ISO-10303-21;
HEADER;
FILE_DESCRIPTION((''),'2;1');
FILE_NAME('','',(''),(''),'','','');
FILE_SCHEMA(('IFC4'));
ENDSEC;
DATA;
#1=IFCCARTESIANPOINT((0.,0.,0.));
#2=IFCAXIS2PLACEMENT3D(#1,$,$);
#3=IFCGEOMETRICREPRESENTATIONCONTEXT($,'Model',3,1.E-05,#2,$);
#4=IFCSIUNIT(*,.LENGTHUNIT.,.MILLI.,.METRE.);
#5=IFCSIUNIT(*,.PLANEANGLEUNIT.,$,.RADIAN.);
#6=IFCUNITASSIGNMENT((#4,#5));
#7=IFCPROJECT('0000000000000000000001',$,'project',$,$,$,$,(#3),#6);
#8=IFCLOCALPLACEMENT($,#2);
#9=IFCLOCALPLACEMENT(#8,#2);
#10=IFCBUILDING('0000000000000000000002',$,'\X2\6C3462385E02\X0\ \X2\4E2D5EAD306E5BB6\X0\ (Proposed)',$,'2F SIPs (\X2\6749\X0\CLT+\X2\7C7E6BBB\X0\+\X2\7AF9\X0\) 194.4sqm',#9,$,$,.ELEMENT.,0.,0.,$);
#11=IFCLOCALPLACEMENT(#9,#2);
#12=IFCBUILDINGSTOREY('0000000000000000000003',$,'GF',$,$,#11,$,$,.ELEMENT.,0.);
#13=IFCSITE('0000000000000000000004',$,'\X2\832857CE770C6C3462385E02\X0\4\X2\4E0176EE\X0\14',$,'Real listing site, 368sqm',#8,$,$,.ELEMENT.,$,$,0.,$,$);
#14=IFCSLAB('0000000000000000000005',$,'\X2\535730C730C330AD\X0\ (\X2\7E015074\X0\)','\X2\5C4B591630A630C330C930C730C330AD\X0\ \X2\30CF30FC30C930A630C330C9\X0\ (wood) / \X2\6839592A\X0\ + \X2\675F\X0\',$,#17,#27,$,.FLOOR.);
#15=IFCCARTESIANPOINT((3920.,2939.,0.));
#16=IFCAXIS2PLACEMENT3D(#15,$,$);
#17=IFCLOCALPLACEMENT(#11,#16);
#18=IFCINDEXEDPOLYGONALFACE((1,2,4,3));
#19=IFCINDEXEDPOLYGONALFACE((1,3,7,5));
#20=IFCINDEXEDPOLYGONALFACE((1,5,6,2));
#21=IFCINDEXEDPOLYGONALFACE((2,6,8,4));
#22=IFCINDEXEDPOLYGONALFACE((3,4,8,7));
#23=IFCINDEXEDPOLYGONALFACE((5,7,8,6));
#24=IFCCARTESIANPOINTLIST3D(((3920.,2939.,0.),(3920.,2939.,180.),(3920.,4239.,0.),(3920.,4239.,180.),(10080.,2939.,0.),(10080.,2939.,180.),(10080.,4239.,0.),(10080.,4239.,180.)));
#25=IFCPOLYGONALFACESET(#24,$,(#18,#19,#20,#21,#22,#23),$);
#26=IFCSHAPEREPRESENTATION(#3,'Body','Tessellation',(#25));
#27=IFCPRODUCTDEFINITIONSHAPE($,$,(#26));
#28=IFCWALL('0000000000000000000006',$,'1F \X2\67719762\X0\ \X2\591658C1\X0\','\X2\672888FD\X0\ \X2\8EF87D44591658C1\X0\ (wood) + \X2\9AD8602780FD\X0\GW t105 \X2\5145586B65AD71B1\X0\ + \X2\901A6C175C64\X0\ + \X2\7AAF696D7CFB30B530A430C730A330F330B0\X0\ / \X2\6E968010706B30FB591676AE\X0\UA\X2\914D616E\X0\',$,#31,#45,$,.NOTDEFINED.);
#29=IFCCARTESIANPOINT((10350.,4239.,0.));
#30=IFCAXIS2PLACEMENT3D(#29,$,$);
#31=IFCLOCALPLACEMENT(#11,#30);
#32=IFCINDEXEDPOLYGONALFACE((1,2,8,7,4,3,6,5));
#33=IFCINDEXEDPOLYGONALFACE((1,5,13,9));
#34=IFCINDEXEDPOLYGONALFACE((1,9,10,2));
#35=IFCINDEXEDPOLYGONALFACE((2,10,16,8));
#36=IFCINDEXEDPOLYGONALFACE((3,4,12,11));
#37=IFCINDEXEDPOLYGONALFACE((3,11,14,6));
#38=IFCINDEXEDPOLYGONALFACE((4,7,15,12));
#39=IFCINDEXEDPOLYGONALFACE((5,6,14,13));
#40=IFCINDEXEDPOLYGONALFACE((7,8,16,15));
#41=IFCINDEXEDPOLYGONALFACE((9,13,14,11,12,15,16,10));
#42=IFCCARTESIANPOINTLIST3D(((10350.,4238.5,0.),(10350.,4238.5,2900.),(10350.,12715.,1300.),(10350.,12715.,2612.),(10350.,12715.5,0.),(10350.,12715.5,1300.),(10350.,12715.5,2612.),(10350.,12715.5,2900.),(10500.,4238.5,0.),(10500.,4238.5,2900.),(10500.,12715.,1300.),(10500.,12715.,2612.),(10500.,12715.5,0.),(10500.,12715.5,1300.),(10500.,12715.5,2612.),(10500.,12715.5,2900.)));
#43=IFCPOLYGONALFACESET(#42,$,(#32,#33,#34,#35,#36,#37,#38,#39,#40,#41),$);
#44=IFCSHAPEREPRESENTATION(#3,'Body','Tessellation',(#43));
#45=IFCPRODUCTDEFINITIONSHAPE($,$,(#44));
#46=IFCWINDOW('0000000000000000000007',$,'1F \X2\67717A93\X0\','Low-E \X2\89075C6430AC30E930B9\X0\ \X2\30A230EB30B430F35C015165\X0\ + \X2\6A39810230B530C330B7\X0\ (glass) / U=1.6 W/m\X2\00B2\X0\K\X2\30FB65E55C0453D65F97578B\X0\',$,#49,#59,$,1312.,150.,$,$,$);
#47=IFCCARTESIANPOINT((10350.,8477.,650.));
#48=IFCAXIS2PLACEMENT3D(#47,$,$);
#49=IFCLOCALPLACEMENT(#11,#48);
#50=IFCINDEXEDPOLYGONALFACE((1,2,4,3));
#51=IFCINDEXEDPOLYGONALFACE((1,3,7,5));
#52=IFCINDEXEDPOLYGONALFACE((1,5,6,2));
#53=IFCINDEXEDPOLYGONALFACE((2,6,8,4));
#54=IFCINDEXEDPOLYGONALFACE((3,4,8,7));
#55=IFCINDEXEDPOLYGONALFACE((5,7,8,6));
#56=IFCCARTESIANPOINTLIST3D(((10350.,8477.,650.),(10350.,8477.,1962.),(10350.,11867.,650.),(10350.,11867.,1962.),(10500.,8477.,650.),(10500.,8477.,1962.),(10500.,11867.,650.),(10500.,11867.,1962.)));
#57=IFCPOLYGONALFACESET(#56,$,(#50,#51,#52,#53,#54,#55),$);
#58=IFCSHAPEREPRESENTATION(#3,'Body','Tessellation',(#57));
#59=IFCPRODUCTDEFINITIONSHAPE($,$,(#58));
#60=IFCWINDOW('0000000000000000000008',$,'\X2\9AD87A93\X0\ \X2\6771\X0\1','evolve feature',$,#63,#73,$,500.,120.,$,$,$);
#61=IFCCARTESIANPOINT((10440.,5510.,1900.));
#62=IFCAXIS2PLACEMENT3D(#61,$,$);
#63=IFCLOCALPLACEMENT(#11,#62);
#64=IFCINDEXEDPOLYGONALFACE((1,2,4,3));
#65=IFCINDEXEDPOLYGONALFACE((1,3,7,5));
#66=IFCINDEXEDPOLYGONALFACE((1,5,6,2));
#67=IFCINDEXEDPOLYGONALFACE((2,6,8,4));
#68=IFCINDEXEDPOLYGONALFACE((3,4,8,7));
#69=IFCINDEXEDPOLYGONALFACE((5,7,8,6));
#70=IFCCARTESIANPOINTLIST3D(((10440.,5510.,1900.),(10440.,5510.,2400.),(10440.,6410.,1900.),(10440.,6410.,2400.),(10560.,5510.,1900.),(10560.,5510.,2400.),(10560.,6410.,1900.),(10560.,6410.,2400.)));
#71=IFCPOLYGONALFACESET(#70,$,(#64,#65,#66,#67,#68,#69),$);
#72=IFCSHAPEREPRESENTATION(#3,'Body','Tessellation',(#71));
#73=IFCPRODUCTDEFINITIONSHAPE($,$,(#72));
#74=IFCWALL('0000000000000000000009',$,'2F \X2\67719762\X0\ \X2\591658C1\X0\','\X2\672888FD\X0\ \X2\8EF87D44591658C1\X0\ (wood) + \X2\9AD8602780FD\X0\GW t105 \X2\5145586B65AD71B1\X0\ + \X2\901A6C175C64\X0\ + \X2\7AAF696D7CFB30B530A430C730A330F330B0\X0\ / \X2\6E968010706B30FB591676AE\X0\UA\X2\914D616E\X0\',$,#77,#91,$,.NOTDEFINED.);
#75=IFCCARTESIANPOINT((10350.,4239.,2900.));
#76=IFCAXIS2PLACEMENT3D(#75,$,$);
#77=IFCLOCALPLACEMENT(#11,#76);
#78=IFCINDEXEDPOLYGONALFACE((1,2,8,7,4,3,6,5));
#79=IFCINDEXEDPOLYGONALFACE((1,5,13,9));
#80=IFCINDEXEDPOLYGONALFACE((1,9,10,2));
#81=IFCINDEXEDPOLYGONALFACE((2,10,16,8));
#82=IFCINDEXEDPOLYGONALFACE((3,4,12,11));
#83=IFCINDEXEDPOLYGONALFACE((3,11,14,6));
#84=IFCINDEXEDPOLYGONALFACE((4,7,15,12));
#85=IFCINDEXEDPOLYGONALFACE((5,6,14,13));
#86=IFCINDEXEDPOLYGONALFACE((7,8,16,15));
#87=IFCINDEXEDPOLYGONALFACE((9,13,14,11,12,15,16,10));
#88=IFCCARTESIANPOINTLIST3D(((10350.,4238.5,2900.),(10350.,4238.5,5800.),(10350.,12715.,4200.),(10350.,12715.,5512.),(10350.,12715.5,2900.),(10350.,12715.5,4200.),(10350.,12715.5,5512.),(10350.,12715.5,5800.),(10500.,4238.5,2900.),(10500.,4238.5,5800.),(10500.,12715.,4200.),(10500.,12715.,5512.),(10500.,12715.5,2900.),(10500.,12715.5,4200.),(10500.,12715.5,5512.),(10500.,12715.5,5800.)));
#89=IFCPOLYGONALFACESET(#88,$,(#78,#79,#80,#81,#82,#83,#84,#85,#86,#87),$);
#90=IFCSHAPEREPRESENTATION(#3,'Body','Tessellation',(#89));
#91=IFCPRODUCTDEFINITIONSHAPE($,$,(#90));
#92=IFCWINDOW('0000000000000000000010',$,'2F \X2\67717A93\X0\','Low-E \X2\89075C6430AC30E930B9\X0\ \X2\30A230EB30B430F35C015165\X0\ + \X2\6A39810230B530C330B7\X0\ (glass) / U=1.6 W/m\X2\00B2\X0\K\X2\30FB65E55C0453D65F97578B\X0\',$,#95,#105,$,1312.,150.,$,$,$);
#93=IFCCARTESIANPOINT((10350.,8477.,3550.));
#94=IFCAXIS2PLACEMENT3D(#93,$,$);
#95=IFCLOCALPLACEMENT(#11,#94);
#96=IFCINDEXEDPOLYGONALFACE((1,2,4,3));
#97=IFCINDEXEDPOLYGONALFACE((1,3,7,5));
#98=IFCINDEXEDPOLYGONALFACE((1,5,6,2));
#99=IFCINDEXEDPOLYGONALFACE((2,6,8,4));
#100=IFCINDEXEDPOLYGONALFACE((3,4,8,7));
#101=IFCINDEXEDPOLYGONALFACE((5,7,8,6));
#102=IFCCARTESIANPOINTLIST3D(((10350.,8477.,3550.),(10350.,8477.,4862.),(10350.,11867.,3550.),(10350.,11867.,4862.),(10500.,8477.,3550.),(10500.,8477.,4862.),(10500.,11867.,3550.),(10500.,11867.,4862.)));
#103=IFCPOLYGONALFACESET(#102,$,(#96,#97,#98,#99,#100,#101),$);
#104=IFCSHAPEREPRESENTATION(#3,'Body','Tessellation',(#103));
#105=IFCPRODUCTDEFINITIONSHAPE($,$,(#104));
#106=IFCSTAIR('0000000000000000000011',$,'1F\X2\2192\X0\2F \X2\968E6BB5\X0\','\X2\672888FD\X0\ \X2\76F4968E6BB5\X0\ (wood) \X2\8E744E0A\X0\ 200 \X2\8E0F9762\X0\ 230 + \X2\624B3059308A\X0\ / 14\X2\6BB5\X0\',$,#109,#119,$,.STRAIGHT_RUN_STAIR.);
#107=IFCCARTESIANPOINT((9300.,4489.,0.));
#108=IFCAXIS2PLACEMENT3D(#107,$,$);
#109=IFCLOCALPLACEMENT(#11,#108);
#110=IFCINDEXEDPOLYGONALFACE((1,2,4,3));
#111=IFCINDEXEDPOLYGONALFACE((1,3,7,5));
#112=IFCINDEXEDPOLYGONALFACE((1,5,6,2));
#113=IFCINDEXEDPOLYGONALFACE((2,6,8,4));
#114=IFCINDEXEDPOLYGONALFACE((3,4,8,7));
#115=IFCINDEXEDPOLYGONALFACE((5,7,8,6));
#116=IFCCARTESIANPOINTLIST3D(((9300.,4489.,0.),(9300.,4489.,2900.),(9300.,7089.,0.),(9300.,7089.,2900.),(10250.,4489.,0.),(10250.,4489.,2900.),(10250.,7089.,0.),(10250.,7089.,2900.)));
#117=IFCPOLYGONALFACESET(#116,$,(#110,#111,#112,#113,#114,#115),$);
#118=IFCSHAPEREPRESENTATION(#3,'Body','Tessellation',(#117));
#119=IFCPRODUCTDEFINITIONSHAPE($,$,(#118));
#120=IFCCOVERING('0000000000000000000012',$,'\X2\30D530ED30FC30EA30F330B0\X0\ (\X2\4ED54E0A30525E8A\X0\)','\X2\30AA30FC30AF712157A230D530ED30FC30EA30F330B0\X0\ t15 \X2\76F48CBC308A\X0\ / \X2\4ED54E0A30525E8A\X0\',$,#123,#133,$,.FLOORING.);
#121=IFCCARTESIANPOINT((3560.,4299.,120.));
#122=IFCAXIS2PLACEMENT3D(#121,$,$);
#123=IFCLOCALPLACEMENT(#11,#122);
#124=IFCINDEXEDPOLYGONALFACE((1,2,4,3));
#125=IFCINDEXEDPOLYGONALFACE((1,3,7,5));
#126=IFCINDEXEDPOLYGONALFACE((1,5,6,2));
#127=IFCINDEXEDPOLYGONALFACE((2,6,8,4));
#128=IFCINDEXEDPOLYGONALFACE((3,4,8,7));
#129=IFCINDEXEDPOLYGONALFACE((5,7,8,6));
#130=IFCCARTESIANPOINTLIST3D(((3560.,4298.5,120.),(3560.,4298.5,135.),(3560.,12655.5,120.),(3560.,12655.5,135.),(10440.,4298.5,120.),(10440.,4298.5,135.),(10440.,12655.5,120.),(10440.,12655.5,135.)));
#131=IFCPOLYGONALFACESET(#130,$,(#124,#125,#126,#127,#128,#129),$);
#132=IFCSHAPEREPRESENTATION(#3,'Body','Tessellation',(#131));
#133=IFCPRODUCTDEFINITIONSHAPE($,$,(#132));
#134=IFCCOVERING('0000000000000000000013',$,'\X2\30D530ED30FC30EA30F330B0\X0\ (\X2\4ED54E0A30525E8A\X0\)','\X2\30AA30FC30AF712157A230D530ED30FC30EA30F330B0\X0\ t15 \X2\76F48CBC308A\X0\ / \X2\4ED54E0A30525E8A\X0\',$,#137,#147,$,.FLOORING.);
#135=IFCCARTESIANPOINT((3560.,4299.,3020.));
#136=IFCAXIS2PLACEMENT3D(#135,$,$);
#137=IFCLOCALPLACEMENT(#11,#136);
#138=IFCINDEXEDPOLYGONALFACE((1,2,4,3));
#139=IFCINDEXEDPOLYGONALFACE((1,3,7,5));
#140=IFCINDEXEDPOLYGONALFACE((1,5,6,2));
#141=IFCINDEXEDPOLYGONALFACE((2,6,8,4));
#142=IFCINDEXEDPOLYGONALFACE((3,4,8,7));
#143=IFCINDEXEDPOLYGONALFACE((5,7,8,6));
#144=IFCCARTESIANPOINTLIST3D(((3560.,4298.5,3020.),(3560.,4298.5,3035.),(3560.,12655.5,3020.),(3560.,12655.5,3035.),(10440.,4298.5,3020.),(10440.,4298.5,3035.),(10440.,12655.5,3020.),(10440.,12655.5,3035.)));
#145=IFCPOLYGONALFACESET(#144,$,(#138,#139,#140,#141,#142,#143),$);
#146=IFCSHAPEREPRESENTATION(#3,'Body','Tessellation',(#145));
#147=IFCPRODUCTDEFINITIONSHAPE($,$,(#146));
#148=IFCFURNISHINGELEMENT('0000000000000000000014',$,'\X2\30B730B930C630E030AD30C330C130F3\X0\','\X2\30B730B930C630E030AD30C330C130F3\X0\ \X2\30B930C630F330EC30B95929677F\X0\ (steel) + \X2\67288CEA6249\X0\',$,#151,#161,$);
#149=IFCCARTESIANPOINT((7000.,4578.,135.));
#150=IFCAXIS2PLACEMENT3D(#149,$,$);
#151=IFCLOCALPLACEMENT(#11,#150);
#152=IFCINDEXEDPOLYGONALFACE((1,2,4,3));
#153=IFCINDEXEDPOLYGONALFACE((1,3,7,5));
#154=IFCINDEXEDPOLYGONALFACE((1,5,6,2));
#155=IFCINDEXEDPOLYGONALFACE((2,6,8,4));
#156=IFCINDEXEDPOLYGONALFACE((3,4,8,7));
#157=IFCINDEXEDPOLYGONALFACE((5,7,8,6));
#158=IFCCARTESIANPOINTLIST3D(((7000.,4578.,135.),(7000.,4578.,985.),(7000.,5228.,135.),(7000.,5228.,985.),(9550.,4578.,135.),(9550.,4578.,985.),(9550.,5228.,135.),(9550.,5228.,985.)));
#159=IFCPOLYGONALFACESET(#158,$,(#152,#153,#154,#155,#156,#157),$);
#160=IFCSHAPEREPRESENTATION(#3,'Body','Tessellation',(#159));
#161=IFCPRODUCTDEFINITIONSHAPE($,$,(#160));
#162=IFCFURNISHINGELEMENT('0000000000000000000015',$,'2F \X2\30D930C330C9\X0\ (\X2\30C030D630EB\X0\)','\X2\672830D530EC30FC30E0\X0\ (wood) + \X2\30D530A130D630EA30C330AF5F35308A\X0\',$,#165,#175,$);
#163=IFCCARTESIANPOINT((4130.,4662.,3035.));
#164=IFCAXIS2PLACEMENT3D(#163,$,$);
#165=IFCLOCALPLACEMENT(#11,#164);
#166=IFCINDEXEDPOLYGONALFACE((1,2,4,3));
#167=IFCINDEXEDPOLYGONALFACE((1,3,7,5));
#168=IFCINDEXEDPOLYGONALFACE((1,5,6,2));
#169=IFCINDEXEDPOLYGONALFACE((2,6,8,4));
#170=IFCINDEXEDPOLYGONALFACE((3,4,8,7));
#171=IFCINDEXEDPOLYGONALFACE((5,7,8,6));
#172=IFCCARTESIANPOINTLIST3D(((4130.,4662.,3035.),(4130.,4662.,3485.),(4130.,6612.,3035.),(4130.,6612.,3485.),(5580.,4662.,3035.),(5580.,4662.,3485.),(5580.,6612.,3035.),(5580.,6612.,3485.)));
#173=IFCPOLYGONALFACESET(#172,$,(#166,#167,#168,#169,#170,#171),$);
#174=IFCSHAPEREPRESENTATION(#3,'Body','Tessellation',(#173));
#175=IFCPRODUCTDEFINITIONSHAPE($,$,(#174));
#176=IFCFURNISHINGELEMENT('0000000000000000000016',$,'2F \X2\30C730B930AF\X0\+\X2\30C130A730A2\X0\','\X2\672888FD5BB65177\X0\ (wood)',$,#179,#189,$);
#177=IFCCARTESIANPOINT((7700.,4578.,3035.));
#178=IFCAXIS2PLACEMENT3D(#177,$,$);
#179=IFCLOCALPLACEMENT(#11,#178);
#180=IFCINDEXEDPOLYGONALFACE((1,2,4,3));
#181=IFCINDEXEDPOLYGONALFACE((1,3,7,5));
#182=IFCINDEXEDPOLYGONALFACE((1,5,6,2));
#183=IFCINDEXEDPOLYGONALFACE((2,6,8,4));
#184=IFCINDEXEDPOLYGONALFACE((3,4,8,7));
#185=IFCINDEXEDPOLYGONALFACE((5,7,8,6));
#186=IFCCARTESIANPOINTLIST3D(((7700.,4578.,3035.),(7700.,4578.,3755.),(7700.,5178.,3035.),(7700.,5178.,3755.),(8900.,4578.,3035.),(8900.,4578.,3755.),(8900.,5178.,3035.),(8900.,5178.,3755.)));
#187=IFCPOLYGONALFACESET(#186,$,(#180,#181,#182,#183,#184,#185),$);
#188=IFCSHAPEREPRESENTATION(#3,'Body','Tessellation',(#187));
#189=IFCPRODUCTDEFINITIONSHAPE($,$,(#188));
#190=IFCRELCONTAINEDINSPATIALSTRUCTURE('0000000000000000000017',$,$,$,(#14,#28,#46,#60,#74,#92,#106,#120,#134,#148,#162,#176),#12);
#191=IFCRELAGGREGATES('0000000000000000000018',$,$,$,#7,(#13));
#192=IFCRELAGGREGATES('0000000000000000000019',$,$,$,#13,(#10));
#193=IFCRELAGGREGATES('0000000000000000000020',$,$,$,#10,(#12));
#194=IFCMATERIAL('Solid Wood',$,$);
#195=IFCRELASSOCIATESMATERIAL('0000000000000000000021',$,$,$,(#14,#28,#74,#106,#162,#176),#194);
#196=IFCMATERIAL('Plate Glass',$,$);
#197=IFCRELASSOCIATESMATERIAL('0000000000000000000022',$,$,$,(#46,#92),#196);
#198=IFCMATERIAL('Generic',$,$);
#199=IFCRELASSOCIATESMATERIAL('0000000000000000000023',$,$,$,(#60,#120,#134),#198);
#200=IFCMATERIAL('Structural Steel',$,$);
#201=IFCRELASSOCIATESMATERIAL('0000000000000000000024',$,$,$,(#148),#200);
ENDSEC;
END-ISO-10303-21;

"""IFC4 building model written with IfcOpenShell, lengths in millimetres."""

from ifc_helpers import new_model, si_unit, frame, frame_2d, origin, place, context, project, spatial, rectangle, extrude, material, element, fill, save


model = new_model("IFC4")

# Units and contexts
model_context = context("Model", 3, precision=1e-05, world=origin())
ifc_project = project(units=[si_unit("LENGTHUNIT", "METRE", prefix="MILLI"), si_unit("PLANEANGLEUNIT", "RADIAN")], contexts=[model_context])

# Site, building, storey
site_placement = place(None, origin())
site = spatial("IfcSite", under=ifc_project, at=site_placement, Name="茨城県水戸市4丁目14", ObjectType="Real listing site, 368sqm", CompositionType="ELEMENT", RefElevation=0.0)
building_placement = place(site_placement, origin())
building = spatial("IfcBuilding", under=site, at=building_placement, Name="水戸市 中庭の家 (Proposed)", ObjectType="2F SIPs (杉CLT+籾殻+竹) 194.4sqm", CompositionType="ELEMENT", ElevationOfRefHeight=0.0, ElevationOfTerrain=0.0)
storey_placement = place(building_placement, origin())
storey = spatial("IfcBuildingStorey", under=building, at=storey_placement, Name="GF", CompositionType="ELEMENT", Elevation=0.0)

# Slab
ifc_material_1 = material(Name="Solid Wood")
slab_placement = place(storey_placement, frame((3920.0, 2939.0, 0.0)))
element("IfcSlab", 1, at=slab_placement, inside=storey, material=ifc_material_1, Name="南デッキ (縁側)", Description="屋外ウッドデッキ ハードウッド (wood) / 根太 + 束", PredefinedType="FLOOR", context=model_context, shape_type="SweptSolid", body=[
    extrude(rectangle(XDim=6160.0, YDim=1300.0, at=frame_2d((3080.0, 650.0))), frame((3920.0, 2939.0, 0.0)), (0.0, 0.0, 1.0), 180.0),
])

# Wall, openings, windows
wall_1_placement = place(storey_placement, frame((10350.0, 4239.0, 0.0)))
wall_1 = element("IfcWall", 2, at=wall_1_placement, inside=storey, material=ifc_material_1, Name="1F 東面 外壁", Description="木製 軸組外壁 (wood) + 高性能GW t105 充填断熱 + 通気層 + 窯業系サイディング / 準耐火・外皮UA配慮", PredefinedType="NOTDEFINED", context=model_context, shape_type="SweptSolid", body=[
    extrude(rectangle(XDim=150.0, YDim=8477.0, at=frame_2d((75.0, 4238.0))), frame((10350.0, 4239.0, 0.0)), (0.0, 0.0, 1.0), 2900.0),
])
opening_1_placement = place(storey_placement, frame((10350.0, 8477.0, 650.0)))
opening_1 = element("IfcOpeningElement", 3, at=opening_1_placement, cuts=wall_1, PredefinedType="NOTDEFINED", context=model_context, shape_type="SweptSolid", body=[
    extrude(rectangle(XDim=150.0, YDim=3390.0, at=frame_2d((75.0, 1695.0))), frame((10350.0, 8477.0, 650.0)), (0.0, 0.0, 1.0), 1312.0),
])
opening_2_placement = place(storey_placement, frame((10440.0, 5510.0, 1900.0)))
opening_2 = element("IfcOpeningElement", 4, at=opening_2_placement, cuts=wall_1, PredefinedType="NOTDEFINED", context=model_context, shape_type="SweptSolid", body=[
    extrude(rectangle(XDim=120.0, YDim=900.0, at=frame_2d((60.0, 450.0))), frame((10440.0, 5510.0, 1900.0)), (0.0, 0.0, 1.0), 500.0),
])
ifc_material_2 = material(Name="Plate Glass")
window_1_placement = place(storey_placement, frame((10350.0, 8477.0, 650.0)))
window_1 = element("IfcWindow", 5, at=window_1_placement, inside=storey, material=ifc_material_2, Name="1F 東窓", Description="Low-E 複層ガラス アルゴン封入 + 樹脂サッシ (glass) / U=1.6 W/m²K・日射取得型", OverallHeight=1312.0, OverallWidth=150.0, context=model_context, shape_type="SweptSolid", body=[
    extrude(rectangle(XDim=150.0, YDim=3390.0, at=frame_2d((75.0, 1695.0))), frame((10350.0, 8477.0, 650.0)), (0.0, 0.0, 1.0), 1312.0),
])
fill(opening_1, window_1)
ifc_material_3 = material(Name="Generic")
window_2_placement = place(storey_placement, frame((10440.0, 5510.0, 1900.0)))
window_2 = element("IfcWindow", 6, at=window_2_placement, inside=storey, material=ifc_material_3, Name="高窓 東1", Description="evolve feature", OverallHeight=500.0, OverallWidth=120.0, context=model_context, shape_type="SweptSolid", body=[
    extrude(rectangle(XDim=120.0, YDim=900.0, at=frame_2d((60.0, 450.0))), frame((10440.0, 5510.0, 1900.0)), (0.0, 0.0, 1.0), 500.0),
])
fill(opening_2, window_2)

# Wall, opening, window
wall_2_placement = place(storey_placement, frame((10350.0, 4239.0, 2900.0)))
wall_2 = element("IfcWall", 7, at=wall_2_placement, inside=storey, material=ifc_material_1, Name="2F 東面 外壁", Description="木製 軸組外壁 (wood) + 高性能GW t105 充填断熱 + 通気層 + 窯業系サイディング / 準耐火・外皮UA配慮", PredefinedType="NOTDEFINED", context=model_context, shape_type="SweptSolid", body=[
    extrude(rectangle(XDim=150.0, YDim=8477.0, at=frame_2d((75.0, 4238.0))), frame((10350.0, 4239.0, 2900.0)), (0.0, 0.0, 1.0), 2900.0),
])
opening_3_placement = place(storey_placement, frame((10350.0, 8477.0, 3550.0)))
opening_3 = element("IfcOpeningElement", 8, at=opening_3_placement, cuts=wall_2, PredefinedType="NOTDEFINED", context=model_context, shape_type="SweptSolid", body=[
    extrude(rectangle(XDim=150.0, YDim=3390.0, at=frame_2d((75.0, 1695.0))), frame((10350.0, 8477.0, 3550.0)), (0.0, 0.0, 1.0), 1312.0),
])
window_3_placement = place(storey_placement, frame((10350.0, 8477.0, 3550.0)))
window_3 = element("IfcWindow", 9, at=window_3_placement, inside=storey, material=ifc_material_2, Name="2F 東窓", Description="Low-E 複層ガラス アルゴン封入 + 樹脂サッシ (glass) / U=1.6 W/m²K・日射取得型", OverallHeight=1312.0, OverallWidth=150.0, context=model_context, shape_type="SweptSolid", body=[
    extrude(rectangle(XDim=150.0, YDim=3390.0, at=frame_2d((75.0, 1695.0))), frame((10350.0, 8477.0, 3550.0)), (0.0, 0.0, 1.0), 1312.0),
])
fill(opening_3, window_3)

# Stair
stair_placement = place(storey_placement, frame((9300.0, 4489.0, 0.0)))
element("IfcStair", 10, at=stair_placement, inside=storey, material=ifc_material_1, Name="1F→2F 階段", Description="木製 直階段 (wood) 蹴上 200 踏面 230 + 手すり / 14段", PredefinedType="STRAIGHT_RUN_STAIR", context=model_context, shape_type="SweptSolid", body=[
    extrude(rectangle(XDim=950.0, YDim=2600.0, at=frame_2d((475.0, 1300.0))), frame((9300.0, 4489.0, 0.0)), (0.0, 0.0, 1.0), 2900.0),
])

# Coverings
covering_1_placement = place(storey_placement, frame((3560.0, 4299.0, 120.0)))
element("IfcCovering", 11, at=covering_1_placement, inside=storey, material=ifc_material_3, Name="フローリング (仕上げ床)", Description="オーク無垢フローリング t15 直貼り / 仕上げ床", PredefinedType="FLOORING", context=model_context, shape_type="SweptSolid", body=[
    extrude(rectangle(XDim=6880.0, YDim=8357.0, at=frame_2d((3440.0, 4178.0))), frame((3560.0, 4299.0, 120.0)), (0.0, 0.0, 1.0), 15.0),
])
covering_2_placement = place(storey_placement, frame((3560.0, 4299.0, 3020.0)))
element("IfcCovering", 12, at=covering_2_placement, inside=storey, material=ifc_material_3, Name="フローリング (仕上げ床)", Description="オーク無垢フローリング t15 直貼り / 仕上げ床", PredefinedType="FLOORING", context=model_context, shape_type="SweptSolid", body=[
    extrude(rectangle(XDim=6880.0, YDim=8357.0, at=frame_2d((3440.0, 4178.0))), frame((3560.0, 4299.0, 3020.0)), (0.0, 0.0, 1.0), 15.0),
])

# Furnishing elements
ifc_material_4 = material(Name="Structural Steel")
furnishing_1_placement = place(storey_placement, frame((7000.0, 4578.0, 135.0)))
element("IfcFurnishingElement", 13, at=furnishing_1_placement, inside=storey, material=ifc_material_4, Name="システムキッチン", Description="システムキッチン ステンレス天板 (steel) + 木質扉", context=model_context, shape_type="SweptSolid", body=[
    extrude(rectangle(XDim=2550.0, YDim=650.0, at=frame_2d((1275.0, 325.0))), frame((7000.0, 4578.0, 135.0)), (0.0, 0.0, 1.0), 850.0),
])
furnishing_2_placement = place(storey_placement, frame((4130.0, 4662.0, 3035.0)))
element("IfcFurnishingElement", 14, at=furnishing_2_placement, inside=storey, material=ifc_material_1, Name="2F ベッド (ダブル)", Description="木フレーム (wood) + ファブリック張り", context=model_context, shape_type="SweptSolid", body=[
    extrude(rectangle(XDim=1450.0, YDim=1950.0, at=frame_2d((725.0, 975.0))), frame((4130.0, 4662.0, 3035.0)), (0.0, 0.0, 1.0), 450.0),
])
furnishing_3_placement = place(storey_placement, frame((7700.0, 4578.0, 3035.0)))
element("IfcFurnishingElement", 15, at=furnishing_3_placement, inside=storey, material=ifc_material_1, Name="2F デスク+チェア", Description="木製家具 (wood)", context=model_context, shape_type="SweptSolid", body=[
    extrude(rectangle(XDim=1200.0, YDim=600.0, at=frame_2d((600.0, 300.0))), frame((7700.0, 4578.0, 3035.0)), (0.0, 0.0, 1.0), 720.0),
])

save(model, "model.ifc")
